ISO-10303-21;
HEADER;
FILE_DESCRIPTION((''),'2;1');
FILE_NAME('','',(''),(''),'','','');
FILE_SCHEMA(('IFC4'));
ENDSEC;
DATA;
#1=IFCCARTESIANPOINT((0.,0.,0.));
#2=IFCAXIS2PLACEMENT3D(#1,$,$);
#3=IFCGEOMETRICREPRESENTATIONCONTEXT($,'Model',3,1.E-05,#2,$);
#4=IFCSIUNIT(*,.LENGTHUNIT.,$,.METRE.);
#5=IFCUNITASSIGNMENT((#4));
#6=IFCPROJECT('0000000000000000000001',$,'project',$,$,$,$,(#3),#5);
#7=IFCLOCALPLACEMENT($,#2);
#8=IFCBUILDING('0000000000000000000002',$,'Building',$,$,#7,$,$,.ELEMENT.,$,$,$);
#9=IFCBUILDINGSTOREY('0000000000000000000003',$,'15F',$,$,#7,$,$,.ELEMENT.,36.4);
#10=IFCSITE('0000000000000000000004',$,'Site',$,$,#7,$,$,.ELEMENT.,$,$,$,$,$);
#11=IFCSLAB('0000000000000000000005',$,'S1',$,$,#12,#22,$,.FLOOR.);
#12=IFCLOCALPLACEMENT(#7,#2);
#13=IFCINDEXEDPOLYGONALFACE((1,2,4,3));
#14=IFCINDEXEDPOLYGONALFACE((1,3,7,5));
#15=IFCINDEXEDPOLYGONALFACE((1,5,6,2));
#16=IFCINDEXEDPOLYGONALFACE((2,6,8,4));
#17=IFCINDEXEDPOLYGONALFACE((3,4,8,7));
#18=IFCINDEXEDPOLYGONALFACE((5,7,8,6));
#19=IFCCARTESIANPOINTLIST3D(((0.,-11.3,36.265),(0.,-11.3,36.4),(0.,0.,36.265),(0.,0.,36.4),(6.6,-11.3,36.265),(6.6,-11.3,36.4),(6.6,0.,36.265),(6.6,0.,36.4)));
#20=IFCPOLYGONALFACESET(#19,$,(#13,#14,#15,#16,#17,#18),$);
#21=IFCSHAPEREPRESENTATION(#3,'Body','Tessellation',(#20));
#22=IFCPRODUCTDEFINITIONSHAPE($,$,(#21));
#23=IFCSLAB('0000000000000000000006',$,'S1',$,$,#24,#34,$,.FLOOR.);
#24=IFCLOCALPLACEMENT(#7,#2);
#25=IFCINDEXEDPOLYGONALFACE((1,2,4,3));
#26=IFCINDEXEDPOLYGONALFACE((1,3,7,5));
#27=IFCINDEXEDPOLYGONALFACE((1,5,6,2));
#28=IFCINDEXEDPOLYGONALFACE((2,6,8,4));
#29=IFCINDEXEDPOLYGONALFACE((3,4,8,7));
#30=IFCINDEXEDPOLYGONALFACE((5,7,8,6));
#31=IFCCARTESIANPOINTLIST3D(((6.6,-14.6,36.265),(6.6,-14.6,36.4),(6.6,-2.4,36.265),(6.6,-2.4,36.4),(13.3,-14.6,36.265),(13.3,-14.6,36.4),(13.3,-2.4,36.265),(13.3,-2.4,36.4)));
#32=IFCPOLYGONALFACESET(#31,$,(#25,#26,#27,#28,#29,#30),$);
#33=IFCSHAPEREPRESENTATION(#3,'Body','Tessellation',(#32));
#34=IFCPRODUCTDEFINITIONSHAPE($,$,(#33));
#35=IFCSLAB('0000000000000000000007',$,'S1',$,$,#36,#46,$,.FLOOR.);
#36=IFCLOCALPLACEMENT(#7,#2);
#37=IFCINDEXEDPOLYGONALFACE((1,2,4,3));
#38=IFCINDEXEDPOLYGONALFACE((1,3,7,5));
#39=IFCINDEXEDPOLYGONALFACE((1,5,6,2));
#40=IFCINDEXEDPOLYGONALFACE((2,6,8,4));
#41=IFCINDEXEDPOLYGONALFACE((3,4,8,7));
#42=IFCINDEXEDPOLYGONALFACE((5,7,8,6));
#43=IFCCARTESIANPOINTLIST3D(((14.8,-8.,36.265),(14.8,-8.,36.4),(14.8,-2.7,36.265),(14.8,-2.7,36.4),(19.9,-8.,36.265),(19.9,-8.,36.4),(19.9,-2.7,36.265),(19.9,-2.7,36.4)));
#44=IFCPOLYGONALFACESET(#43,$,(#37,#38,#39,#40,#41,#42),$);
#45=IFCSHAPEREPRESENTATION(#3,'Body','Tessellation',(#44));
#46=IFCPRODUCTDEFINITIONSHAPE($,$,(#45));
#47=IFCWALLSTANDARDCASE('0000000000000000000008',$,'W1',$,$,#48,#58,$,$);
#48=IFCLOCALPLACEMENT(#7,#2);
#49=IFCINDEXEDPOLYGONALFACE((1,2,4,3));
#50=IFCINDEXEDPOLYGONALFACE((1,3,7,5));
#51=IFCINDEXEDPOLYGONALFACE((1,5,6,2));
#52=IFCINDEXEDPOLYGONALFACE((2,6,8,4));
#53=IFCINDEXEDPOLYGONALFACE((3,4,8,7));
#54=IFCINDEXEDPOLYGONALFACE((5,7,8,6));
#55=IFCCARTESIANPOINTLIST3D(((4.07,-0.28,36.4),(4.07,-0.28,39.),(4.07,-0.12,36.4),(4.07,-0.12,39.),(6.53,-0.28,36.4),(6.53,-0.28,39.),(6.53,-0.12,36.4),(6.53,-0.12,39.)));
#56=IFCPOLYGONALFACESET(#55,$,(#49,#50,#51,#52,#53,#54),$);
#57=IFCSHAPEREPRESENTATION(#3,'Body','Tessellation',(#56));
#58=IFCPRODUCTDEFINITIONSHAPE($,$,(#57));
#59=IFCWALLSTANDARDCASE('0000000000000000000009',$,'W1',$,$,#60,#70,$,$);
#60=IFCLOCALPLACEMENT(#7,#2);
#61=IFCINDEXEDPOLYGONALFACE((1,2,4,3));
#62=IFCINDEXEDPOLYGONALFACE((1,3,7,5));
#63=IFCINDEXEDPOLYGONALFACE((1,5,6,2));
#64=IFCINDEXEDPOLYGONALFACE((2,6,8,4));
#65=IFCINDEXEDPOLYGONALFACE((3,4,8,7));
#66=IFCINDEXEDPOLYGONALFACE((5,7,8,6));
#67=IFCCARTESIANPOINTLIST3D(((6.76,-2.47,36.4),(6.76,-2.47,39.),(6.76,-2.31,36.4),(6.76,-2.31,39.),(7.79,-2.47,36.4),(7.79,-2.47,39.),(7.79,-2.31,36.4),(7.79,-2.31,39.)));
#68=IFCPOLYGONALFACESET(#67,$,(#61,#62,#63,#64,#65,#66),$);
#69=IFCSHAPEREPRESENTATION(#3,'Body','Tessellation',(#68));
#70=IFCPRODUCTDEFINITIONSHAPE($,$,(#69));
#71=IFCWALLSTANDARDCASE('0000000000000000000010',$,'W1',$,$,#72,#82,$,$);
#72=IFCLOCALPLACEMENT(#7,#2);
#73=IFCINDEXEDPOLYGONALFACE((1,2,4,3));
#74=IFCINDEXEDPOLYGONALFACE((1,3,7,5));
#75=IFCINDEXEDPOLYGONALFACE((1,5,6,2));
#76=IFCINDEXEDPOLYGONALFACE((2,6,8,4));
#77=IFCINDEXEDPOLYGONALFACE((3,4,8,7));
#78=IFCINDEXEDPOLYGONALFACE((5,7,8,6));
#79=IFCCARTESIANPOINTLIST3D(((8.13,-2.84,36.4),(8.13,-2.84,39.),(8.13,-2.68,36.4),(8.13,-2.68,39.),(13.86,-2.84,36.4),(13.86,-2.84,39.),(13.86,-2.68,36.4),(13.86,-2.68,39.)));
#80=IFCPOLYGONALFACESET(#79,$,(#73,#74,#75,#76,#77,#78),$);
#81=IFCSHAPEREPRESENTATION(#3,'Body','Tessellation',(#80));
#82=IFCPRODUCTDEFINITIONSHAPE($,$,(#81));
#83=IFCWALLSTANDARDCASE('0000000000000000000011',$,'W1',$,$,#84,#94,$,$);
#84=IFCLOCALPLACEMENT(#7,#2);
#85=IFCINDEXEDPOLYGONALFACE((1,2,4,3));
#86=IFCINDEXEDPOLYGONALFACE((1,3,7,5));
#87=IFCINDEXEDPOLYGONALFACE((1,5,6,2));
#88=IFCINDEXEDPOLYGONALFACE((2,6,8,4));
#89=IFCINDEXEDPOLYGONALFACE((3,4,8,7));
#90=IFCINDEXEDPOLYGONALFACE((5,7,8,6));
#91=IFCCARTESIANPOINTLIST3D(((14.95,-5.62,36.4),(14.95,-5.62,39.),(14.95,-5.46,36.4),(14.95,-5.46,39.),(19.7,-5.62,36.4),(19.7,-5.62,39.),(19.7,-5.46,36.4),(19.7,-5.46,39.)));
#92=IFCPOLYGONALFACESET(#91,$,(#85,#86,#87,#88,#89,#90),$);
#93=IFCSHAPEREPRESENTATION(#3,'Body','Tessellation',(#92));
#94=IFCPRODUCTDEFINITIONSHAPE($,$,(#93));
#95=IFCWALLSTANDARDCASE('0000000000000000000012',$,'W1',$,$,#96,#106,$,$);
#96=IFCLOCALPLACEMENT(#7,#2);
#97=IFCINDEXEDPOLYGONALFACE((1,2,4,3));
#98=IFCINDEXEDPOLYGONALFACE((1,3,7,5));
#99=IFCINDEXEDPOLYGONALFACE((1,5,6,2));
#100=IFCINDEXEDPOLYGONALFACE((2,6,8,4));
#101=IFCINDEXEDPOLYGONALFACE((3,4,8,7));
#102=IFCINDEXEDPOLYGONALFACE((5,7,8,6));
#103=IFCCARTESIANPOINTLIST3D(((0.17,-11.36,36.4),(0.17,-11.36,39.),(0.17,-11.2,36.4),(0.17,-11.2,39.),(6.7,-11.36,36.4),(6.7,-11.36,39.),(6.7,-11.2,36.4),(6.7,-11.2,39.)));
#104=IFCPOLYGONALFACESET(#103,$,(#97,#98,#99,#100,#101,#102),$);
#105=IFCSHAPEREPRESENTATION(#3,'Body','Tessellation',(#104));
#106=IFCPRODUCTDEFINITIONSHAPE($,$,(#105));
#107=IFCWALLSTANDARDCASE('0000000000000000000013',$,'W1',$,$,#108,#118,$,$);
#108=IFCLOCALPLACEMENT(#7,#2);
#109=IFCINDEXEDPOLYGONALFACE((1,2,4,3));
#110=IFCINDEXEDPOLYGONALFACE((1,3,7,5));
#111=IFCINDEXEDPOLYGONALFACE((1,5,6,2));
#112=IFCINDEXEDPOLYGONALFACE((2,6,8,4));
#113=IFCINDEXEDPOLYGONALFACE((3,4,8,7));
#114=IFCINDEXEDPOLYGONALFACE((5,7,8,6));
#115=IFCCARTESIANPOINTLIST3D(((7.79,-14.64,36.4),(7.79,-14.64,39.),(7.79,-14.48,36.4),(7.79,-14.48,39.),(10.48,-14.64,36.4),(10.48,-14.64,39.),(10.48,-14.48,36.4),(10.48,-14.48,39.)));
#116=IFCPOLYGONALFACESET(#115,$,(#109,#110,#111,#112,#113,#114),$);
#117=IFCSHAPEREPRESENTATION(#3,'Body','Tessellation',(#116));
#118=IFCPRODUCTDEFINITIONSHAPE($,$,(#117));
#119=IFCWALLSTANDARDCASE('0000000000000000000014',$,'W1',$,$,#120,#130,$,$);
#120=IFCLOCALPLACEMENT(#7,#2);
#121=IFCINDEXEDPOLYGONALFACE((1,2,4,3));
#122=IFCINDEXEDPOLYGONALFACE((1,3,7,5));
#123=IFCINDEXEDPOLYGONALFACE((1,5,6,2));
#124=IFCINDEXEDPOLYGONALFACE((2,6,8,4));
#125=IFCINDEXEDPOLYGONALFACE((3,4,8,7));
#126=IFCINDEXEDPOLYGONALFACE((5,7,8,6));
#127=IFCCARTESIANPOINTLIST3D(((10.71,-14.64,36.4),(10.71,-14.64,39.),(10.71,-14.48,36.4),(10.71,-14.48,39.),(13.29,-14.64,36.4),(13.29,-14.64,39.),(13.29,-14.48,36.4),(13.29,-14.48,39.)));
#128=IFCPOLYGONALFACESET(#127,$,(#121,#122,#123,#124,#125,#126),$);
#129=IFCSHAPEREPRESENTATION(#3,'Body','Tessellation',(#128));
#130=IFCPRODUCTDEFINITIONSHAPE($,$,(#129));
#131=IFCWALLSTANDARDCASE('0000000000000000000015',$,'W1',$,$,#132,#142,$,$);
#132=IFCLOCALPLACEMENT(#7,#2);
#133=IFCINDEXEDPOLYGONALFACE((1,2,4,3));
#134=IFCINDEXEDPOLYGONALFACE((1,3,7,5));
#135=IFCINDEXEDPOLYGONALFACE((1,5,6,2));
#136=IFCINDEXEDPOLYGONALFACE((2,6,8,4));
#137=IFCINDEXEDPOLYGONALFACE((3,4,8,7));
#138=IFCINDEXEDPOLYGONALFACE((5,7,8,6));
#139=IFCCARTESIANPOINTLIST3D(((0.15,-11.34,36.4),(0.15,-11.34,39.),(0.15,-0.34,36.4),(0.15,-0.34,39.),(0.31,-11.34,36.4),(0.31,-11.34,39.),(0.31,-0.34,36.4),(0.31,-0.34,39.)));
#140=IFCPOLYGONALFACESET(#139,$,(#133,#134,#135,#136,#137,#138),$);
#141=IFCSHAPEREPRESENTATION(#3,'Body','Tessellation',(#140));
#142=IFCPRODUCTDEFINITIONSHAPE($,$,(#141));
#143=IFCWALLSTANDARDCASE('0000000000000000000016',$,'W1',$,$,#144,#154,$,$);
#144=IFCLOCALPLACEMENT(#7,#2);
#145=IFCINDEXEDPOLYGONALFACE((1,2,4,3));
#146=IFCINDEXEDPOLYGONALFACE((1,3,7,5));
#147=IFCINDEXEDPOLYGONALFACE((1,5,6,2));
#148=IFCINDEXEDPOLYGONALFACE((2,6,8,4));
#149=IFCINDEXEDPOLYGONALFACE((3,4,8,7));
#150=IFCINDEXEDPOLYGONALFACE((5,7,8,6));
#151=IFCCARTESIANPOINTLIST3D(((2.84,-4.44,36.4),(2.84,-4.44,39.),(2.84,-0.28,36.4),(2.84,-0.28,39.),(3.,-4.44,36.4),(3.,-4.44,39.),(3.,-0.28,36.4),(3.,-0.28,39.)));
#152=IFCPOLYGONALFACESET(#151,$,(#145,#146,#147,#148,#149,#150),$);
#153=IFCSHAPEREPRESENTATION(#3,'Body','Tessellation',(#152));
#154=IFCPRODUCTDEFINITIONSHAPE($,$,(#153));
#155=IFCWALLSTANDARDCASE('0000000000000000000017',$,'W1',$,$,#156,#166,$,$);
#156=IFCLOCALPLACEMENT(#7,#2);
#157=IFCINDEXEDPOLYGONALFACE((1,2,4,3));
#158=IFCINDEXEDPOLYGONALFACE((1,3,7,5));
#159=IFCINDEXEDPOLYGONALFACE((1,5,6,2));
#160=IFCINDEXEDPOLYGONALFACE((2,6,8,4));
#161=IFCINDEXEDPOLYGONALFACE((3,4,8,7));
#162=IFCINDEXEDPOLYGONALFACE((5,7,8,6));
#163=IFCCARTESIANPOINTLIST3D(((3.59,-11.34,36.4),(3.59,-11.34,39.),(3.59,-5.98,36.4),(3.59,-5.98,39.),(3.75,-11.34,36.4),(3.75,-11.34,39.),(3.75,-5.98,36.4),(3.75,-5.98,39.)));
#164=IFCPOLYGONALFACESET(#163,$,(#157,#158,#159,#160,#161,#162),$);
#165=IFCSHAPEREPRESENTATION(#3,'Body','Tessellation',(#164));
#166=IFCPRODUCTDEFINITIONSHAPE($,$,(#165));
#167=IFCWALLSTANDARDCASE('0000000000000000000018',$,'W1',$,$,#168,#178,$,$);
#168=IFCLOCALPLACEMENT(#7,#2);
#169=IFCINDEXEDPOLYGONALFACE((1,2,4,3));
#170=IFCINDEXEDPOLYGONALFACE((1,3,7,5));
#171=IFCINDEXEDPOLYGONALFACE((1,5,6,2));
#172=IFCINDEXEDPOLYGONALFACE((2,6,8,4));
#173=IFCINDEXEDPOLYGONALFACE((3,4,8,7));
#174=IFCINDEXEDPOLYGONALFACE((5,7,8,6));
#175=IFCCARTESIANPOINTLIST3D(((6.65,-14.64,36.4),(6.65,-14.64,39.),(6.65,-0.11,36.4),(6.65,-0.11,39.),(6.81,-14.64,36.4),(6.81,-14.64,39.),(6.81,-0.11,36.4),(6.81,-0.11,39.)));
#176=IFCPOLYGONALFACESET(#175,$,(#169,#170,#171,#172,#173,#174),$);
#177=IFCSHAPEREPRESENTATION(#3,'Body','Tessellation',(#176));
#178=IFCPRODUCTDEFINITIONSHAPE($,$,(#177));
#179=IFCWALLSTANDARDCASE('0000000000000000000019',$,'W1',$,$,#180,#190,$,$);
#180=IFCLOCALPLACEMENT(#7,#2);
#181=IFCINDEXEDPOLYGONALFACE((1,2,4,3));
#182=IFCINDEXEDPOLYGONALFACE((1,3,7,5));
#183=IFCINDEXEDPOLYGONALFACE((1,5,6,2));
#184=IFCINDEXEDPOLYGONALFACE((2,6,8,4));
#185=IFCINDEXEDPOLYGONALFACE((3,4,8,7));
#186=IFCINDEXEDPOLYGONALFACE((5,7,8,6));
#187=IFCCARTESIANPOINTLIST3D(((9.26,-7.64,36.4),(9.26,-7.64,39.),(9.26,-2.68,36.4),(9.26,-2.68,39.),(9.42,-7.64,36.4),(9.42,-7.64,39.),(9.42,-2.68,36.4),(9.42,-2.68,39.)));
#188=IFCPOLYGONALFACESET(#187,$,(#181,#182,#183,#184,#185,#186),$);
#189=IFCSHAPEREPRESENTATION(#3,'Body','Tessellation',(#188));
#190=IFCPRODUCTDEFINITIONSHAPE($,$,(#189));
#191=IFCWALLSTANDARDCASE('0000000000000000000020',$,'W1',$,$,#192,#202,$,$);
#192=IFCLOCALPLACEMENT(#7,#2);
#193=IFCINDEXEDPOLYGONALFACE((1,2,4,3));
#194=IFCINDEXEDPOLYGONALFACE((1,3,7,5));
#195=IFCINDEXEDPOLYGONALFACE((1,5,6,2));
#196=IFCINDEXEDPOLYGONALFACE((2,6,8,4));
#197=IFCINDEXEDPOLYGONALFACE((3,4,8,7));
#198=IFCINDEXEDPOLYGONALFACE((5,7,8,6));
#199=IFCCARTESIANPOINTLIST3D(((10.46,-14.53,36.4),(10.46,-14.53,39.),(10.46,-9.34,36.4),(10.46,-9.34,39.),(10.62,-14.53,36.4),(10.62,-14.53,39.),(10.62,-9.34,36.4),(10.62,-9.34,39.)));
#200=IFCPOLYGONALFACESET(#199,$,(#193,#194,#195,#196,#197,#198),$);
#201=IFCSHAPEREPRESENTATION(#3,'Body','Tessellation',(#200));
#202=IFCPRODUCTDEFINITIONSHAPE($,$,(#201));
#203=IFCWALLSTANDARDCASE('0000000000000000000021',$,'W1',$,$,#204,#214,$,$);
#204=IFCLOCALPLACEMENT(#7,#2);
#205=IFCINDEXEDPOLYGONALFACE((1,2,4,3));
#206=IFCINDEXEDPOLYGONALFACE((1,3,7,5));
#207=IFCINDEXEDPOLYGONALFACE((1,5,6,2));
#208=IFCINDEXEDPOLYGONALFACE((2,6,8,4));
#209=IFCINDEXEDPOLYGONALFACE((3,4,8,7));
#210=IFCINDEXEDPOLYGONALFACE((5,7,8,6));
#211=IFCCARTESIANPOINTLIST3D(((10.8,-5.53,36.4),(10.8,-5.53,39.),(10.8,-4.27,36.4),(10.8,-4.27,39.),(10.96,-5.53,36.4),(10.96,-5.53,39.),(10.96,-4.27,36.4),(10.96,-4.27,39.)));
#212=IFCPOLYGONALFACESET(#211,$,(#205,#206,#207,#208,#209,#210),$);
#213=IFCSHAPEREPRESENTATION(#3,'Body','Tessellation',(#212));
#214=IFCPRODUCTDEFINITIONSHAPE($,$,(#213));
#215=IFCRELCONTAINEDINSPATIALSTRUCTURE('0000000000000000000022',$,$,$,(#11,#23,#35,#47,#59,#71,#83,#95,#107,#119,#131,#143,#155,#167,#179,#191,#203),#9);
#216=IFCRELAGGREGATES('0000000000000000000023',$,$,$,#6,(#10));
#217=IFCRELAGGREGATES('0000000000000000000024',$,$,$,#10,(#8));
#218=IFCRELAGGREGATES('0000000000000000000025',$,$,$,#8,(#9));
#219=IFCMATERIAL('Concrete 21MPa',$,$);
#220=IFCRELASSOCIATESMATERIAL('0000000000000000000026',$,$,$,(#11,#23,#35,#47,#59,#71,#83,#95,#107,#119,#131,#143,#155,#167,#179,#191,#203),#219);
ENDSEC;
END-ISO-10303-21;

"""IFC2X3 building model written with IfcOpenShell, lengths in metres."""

from ifc_helpers import new_model, si_unit, frame, origin, origin_2d, place, context, project, spatial, rectangle, extrude, material, element, save


model = new_model("IFC2X3")

# Units and contexts
model_context = context("Model", 3, precision=1e-05, world=origin())
ifc_project = project(units=[si_unit("LENGTHUNIT", "METRE")], contexts=[model_context])

# Site, building, storey
placement = place(None, origin())
site = spatial("IfcSite", under=ifc_project, at=placement, Name="Site", CompositionType="ELEMENT")
building = spatial("IfcBuilding", under=site, at=placement, Name="Building", CompositionType="ELEMENT")
storey = spatial("IfcBuildingStorey", under=building, at=placement, Name="15F", CompositionType="ELEMENT", Elevation=36.4)

# Slabs
ifc_material_1 = material(Name="Concrete 21MPa")
slab_1_placement = place(None, frame((3.3, -5.65, 36.265)))
element("IfcSlab", 1, at=slab_1_placement, inside=storey, material=ifc_material_1, Name="S1", PredefinedType="FLOOR", context=model_context, shape_type="SweptSolid", body=[
    extrude(rectangle(XDim=6.6, YDim=11.3, at=origin_2d()), origin(), (0.0, 0.0, 1.0), 0.135),
])
slab_2_placement = place(None, frame((9.95, -8.5, 36.265)))
element("IfcSlab", 2, at=slab_2_placement, inside=storey, material=ifc_material_1, Name="S1", PredefinedType="FLOOR", context=model_context, shape_type="SweptSolid", body=[
    extrude(rectangle(XDim=6.7, YDim=12.2, at=origin_2d()), origin(), (0.0, 0.0, 1.0), 0.135),
])
slab_3_placement = place(None, frame((17.35, -5.35, 36.265)))
element("IfcSlab", 3, at=slab_3_placement, inside=storey, material=ifc_material_1, Name="S1", PredefinedType="FLOOR", context=model_context, shape_type="SweptSolid", body=[
    extrude(rectangle(XDim=5.1, YDim=5.3, at=origin_2d()), origin(), (0.0, 0.0, 1.0), 0.135),
])

# Walls
wall_1_placement = place(None, frame((5.3, -0.2, 36.4)))
element("IfcWallStandardCase", 4, at=wall_1_placement, inside=storey, material=ifc_material_1, Name="W1", context=model_context, shape_type="SweptSolid", body=[
    extrude(rectangle(XDim=2.46, YDim=0.16, at=origin_2d()), origin(), (0.0, 0.0, 1.0), 2.6),
])
wall_2_placement = place(None, frame((7.275, -2.39, 36.4)))
element("IfcWallStandardCase", 5, at=wall_2_placement, inside=storey, material=ifc_material_1, Name="W1", context=model_context, shape_type="SweptSolid", body=[
    extrude(rectangle(XDim=1.03, YDim=0.16, at=origin_2d()), origin(), (0.0, 0.0, 1.0), 2.6),
])
wall_3_placement = place(None, frame((10.995, -2.76, 36.4)))
element("IfcWallStandardCase", 6, at=wall_3_placement, inside=storey, material=ifc_material_1, Name="W1", context=model_context, shape_type="SweptSolid", body=[
    extrude(rectangle(XDim=5.73, YDim=0.16, at=origin_2d()), origin(), (0.0, 0.0, 1.0), 2.6),
])
wall_4_placement = place(None, frame((17.325, -5.54, 36.4)))
element("IfcWallStandardCase", 7, at=wall_4_placement, inside=storey, material=ifc_material_1, Name="W1", context=model_context, shape_type="SweptSolid", body=[
    extrude(rectangle(XDim=4.75, YDim=0.16, at=origin_2d()), origin(), (0.0, 0.0, 1.0), 2.6),
])
wall_5_placement = place(None, frame((3.435, -11.28, 36.4)))
element("IfcWallStandardCase", 8, at=wall_5_placement, inside=storey, material=ifc_material_1, Name="W1", context=model_context, shape_type="SweptSolid", body=[
    extrude(rectangle(XDim=6.53, YDim=0.16, at=origin_2d()), origin(), (0.0, 0.0, 1.0), 2.6),
])
wall_6_placement = place(None, frame((9.135, -14.56, 36.4)))
element("IfcWallStandardCase", 9, at=wall_6_placement, inside=storey, material=ifc_material_1, Name="W1", context=model_context, shape_type="SweptSolid", body=[
    extrude(rectangle(XDim=2.69, YDim=0.16, at=origin_2d()), origin(), (0.0, 0.0, 1.0), 2.6),
])
wall_7_placement = place(None, frame((12.0, -14.56, 36.4)))
element("IfcWallStandardCase", 10, at=wall_7_placement, inside=storey, material=ifc_material_1, Name="W1", context=model_context, shape_type="SweptSolid", body=[
    extrude(rectangle(XDim=2.58, YDim=0.16, at=origin_2d()), origin(), (0.0, 0.0, 1.0), 2.6),
])
wall_8_placement = place(None, frame((0.23, -5.84, 36.4)))
element("IfcWallStandardCase", 11, at=wall_8_placement, inside=storey, material=ifc_material_1, Name="W1", context=model_context, shape_type="SweptSolid", body=[
    extrude(rectangle(XDim=0.16, YDim=11.0, at=origin_2d()), origin(), (0.0, 0.0, 1.0), 2.6),
])
wall_9_placement = place(None, frame((2.92, -2.36, 36.4)))
element("IfcWallStandardCase", 12, at=wall_9_placement, inside=storey, material=ifc_material_1, Name="W1", context=model_context, shape_type="SweptSolid", body=[
    extrude(rectangle(XDim=0.16, YDim=4.16, at=origin_2d()), origin(), (0.0, 0.0, 1.0), 2.6),
])
wall_10_placement = place(None, frame((3.67, -8.66, 36.4)))
element("IfcWallStandardCase", 13, at=wall_10_placement, inside=storey, material=ifc_material_1, Name="W1", context=model_context, shape_type="SweptSolid", body=[
    extrude(rectangle(XDim=0.16, YDim=5.36, at=origin_2d()), origin(), (0.0, 0.0, 1.0), 2.6),
])
wall_11_placement = place(None, frame((6.73, -7.375, 36.4)))
element("IfcWallStandardCase", 14, at=wall_11_placement, inside=storey, material=ifc_material_1, Name="W1", context=model_context, shape_type="SweptSolid", body=[
    extrude(rectangle(XDim=0.16, YDim=14.53, at=origin_2d()), origin(), (0.0, 0.0, 1.0), 2.6),
])
wall_12_placement = place(None, frame((9.34, -5.16, 36.4)))
element("IfcWallStandardCase", 15, at=wall_12_placement, inside=storey, material=ifc_material_1, Name="W1", context=model_context, shape_type="SweptSolid", body=[
    extrude(rectangle(XDim=0.16, YDim=4.96, at=origin_2d()), origin(), (0.0, 0.0, 1.0), 2.6),
])
wall_13_placement = place(None, frame((10.54, -11.935, 36.4)))
element("IfcWallStandardCase", 16, at=wall_13_placement, inside=storey, material=ifc_material_1, Name="W1", context=model_context, shape_type="SweptSolid", body=[
    extrude(rectangle(XDim=0.16, YDim=5.19, at=origin_2d()), origin(), (0.0, 0.0, 1.0), 2.6),
])
wall_14_placement = place(None, frame((10.88, -4.9, 36.4)))
element("IfcWallStandardCase", 17, at=wall_14_placement, inside=storey, material=ifc_material_1, Name="W1", context=model_context, shape_type="SweptSolid", body=[
    extrude(rectangle(XDim=0.16, YDim=1.26, at=origin_2d()), origin(), (0.0, 0.0, 1.0), 2.6),
])

save(model, "model.ifc")
